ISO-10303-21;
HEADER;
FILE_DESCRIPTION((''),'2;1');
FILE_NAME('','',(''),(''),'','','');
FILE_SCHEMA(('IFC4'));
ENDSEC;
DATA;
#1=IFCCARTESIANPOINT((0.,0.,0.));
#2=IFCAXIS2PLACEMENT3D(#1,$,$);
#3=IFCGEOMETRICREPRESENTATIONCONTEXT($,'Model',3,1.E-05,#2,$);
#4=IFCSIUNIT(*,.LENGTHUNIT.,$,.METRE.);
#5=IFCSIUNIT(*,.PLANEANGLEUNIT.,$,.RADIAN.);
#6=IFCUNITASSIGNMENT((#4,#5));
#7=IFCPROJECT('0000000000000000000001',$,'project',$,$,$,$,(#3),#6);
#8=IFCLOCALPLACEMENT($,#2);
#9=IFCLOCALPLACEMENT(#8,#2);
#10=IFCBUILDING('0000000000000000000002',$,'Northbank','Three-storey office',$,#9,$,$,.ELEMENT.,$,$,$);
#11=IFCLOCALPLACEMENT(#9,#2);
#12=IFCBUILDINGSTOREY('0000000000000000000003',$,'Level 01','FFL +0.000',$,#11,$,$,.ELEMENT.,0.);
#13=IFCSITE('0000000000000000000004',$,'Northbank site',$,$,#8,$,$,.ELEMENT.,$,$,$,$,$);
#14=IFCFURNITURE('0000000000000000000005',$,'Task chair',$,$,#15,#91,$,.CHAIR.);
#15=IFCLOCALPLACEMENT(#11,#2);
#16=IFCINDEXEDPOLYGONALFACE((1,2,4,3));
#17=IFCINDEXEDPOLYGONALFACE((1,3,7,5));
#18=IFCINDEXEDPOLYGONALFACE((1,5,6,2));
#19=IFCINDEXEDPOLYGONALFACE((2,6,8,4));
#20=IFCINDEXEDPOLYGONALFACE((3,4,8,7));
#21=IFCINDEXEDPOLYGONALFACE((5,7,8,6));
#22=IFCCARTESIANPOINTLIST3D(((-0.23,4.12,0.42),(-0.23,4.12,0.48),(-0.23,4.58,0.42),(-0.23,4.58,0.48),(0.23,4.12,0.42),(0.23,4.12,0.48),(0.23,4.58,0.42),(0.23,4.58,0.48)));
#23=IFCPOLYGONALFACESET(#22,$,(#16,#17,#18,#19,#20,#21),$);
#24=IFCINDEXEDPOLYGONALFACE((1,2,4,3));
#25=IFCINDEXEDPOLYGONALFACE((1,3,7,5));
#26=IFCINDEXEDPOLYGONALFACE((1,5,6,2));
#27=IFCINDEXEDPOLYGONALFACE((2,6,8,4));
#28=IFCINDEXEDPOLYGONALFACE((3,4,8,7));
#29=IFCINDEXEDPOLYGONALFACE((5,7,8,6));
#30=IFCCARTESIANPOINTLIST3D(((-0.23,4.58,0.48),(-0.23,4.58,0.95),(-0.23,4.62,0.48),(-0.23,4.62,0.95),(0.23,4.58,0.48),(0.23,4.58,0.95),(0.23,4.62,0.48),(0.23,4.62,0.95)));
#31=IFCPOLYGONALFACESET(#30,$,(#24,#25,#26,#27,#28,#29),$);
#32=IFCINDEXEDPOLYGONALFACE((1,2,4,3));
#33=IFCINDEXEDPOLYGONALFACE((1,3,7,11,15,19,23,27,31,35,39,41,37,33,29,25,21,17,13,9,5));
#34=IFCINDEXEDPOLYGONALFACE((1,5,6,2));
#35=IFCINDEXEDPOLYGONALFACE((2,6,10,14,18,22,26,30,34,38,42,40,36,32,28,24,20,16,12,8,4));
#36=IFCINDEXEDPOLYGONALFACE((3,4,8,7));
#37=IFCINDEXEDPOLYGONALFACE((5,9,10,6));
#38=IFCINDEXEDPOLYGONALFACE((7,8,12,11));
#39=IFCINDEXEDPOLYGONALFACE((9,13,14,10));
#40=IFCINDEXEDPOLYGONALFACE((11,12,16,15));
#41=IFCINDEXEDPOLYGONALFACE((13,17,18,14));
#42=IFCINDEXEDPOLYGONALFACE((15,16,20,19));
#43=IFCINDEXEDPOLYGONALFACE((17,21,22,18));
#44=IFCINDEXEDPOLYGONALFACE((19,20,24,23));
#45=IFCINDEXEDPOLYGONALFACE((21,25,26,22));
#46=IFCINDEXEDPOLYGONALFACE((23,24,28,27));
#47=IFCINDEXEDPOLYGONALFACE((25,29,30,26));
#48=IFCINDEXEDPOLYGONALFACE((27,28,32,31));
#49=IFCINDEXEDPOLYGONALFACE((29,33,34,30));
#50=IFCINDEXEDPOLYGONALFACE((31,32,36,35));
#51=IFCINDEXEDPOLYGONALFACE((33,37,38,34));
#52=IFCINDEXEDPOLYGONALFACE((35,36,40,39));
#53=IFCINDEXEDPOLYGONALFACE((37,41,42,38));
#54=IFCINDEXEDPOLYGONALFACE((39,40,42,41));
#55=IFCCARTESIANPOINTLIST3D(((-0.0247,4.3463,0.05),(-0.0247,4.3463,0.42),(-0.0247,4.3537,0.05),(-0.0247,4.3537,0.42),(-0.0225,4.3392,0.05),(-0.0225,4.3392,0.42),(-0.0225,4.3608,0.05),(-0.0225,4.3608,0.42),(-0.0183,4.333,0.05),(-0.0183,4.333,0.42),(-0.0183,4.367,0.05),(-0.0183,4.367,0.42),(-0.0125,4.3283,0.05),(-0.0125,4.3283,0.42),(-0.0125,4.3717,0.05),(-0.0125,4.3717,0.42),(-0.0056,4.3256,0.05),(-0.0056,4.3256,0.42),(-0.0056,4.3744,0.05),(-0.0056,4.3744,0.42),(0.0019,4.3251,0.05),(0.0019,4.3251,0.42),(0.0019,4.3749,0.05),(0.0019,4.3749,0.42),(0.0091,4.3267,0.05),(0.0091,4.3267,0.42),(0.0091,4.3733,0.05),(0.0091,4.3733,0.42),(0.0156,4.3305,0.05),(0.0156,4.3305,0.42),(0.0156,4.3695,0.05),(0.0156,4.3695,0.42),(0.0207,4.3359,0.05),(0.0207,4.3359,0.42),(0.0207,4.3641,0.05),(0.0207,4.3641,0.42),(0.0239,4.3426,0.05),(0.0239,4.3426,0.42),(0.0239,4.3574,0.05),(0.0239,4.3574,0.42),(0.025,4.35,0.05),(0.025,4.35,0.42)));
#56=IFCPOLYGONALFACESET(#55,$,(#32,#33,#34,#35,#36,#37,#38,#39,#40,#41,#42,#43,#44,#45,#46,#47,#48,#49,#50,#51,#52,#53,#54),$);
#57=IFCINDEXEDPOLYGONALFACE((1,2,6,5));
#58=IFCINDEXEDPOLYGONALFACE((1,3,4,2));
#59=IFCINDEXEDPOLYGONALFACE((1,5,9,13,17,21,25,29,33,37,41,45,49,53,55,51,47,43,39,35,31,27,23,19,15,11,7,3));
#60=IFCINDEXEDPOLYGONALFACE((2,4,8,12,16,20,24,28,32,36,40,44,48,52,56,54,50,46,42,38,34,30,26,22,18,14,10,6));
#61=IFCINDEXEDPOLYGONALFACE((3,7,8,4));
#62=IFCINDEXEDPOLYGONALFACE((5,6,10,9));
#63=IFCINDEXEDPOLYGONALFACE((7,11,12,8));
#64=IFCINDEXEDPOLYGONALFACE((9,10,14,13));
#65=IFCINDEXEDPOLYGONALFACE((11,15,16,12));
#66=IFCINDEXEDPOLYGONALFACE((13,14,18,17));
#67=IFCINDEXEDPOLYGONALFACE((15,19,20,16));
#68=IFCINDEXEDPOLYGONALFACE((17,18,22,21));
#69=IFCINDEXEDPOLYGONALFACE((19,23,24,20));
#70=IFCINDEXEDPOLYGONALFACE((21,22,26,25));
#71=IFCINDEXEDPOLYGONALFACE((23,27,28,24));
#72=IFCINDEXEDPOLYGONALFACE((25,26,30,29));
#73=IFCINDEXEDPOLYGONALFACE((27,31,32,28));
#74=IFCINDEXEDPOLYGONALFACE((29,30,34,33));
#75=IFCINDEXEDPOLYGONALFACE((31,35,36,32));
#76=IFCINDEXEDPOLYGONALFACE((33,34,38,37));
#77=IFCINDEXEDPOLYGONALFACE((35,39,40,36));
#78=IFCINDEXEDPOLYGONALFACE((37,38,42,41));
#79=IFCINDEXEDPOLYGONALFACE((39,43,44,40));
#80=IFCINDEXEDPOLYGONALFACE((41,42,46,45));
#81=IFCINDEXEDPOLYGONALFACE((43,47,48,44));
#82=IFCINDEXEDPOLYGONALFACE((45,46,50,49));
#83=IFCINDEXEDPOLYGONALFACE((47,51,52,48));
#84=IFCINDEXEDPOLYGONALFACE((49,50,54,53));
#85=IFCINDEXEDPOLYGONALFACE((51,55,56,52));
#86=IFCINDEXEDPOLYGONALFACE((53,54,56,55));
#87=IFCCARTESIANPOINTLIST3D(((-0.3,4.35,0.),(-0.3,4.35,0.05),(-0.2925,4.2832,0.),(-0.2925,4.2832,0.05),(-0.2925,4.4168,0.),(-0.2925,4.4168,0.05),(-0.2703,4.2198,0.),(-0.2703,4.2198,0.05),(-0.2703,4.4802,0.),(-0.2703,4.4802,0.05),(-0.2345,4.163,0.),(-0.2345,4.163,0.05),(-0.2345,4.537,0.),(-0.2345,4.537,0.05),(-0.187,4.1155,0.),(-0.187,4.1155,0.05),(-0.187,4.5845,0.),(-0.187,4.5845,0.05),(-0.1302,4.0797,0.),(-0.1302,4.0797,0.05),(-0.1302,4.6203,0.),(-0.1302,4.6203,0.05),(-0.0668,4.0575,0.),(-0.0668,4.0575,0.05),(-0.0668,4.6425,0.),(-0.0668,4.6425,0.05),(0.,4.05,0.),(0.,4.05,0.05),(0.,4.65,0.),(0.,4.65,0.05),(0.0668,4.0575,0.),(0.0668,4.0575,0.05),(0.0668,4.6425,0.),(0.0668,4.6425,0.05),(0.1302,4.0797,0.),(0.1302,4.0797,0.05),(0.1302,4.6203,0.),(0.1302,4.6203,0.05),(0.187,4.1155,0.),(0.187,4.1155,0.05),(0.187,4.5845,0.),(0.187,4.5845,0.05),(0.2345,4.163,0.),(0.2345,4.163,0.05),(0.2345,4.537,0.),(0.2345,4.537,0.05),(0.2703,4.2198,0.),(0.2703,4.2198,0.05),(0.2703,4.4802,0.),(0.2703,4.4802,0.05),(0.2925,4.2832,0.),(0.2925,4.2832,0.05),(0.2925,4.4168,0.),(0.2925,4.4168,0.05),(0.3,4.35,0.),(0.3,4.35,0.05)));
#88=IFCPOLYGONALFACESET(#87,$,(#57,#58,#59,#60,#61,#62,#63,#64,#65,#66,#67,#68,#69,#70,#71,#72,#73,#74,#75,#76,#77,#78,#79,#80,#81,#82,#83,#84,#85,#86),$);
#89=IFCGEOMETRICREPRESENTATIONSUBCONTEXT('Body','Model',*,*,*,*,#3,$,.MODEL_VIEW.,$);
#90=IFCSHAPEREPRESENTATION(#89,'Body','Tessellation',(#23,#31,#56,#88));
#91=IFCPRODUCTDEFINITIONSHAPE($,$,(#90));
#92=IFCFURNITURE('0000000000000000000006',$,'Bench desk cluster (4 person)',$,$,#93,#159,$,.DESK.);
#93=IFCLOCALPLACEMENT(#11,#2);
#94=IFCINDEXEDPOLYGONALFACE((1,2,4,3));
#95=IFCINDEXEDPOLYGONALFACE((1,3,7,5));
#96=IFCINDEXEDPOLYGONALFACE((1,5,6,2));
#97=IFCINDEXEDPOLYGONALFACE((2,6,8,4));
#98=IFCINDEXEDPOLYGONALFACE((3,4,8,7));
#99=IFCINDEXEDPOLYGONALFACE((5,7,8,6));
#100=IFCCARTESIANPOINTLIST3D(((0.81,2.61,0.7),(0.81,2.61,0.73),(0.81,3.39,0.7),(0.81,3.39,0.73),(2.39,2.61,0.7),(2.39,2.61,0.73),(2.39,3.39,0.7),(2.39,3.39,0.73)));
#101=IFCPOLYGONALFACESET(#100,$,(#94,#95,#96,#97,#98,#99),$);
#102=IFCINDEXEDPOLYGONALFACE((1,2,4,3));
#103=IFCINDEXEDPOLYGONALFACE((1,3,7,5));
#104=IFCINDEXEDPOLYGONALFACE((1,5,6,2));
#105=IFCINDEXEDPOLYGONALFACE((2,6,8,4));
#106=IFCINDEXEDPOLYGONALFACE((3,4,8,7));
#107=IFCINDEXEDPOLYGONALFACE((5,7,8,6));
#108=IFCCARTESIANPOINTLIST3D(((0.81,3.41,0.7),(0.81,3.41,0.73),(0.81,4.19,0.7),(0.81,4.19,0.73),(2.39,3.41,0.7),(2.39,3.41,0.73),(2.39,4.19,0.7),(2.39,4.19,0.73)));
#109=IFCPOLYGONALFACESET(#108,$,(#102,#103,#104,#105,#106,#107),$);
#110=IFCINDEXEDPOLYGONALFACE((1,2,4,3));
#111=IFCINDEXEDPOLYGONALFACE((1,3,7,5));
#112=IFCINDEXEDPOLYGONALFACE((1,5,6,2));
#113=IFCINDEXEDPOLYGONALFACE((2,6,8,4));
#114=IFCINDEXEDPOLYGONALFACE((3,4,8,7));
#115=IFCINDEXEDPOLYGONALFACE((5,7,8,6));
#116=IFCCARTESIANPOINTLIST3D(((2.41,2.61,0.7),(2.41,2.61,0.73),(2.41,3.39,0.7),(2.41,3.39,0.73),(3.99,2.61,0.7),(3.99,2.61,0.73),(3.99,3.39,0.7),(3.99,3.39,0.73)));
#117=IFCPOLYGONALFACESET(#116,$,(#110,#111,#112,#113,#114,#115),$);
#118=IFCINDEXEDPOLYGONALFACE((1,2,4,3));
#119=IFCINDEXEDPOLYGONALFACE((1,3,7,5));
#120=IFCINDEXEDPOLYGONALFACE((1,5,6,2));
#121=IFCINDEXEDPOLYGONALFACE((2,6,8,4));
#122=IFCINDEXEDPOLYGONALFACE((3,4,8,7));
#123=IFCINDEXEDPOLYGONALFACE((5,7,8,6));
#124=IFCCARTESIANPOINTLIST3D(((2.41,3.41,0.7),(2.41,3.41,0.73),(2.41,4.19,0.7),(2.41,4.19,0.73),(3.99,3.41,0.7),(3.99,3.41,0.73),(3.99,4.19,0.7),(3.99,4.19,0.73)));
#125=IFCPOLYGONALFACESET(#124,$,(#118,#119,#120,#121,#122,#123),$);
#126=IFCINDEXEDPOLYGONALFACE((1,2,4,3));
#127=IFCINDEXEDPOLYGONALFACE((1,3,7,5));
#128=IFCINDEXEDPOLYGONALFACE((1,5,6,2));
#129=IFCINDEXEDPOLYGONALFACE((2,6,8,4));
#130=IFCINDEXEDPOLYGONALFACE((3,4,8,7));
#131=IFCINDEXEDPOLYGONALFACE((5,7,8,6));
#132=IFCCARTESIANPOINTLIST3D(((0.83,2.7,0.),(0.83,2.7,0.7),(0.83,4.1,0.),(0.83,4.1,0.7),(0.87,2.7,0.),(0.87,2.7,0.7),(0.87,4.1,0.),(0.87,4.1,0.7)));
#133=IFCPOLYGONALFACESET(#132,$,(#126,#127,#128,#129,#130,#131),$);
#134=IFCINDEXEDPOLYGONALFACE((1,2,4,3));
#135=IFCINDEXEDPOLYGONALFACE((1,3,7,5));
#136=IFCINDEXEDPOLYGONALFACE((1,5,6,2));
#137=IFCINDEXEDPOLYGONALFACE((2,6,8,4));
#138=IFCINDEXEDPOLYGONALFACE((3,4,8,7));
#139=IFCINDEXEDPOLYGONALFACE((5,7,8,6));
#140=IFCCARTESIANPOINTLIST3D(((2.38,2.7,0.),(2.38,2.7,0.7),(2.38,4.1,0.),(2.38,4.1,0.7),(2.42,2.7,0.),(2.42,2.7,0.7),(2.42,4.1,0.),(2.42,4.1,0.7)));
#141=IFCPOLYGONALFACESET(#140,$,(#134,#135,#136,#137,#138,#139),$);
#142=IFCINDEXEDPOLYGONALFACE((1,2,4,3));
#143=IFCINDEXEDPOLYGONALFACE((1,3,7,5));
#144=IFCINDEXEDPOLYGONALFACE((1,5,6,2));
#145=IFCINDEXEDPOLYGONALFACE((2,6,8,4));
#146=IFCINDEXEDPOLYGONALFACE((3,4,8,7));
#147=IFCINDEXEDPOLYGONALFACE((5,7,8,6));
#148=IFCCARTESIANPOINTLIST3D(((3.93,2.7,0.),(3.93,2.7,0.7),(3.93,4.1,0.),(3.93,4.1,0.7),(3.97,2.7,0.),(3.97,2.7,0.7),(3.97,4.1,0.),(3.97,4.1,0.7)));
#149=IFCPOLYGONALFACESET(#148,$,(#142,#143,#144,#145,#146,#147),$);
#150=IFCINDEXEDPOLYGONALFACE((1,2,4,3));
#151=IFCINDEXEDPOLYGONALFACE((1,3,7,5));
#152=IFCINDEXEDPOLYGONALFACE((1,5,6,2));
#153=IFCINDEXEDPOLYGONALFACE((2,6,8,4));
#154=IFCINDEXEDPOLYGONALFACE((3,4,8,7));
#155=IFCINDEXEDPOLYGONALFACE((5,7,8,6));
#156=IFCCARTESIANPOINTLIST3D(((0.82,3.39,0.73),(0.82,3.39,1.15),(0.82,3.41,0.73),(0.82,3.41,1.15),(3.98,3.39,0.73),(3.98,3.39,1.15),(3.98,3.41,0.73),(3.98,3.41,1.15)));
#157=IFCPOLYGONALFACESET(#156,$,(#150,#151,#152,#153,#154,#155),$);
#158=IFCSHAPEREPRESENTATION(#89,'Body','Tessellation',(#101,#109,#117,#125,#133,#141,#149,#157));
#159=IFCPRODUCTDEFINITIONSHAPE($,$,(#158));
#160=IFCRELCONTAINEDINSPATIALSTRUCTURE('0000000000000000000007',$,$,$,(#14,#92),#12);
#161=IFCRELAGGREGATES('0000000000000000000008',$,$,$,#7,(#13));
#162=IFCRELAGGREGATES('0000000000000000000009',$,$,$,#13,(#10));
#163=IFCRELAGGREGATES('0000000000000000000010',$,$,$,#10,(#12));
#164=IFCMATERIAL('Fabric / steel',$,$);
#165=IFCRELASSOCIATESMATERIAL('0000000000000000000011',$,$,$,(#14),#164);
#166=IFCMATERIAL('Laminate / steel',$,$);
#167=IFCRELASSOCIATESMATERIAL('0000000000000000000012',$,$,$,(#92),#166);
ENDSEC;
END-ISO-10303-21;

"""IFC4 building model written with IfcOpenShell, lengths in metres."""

from ifc_helpers import new_model, si_unit, frame, origin, place, context, subcontext, project, spatial, rectangle, circle, extrude, material, element, save


model = new_model("IFC4")

# Units and contexts
model_context = context("Model", 3, precision=1e-05, world=origin())
body_context = subcontext(model_context, "Body", "Model", "MODEL_VIEW")
ifc_project = project(units=[si_unit("LENGTHUNIT", "METRE"), si_unit("PLANEANGLEUNIT", "RADIAN")], contexts=[model_context])

# Site, building, storey
site_placement = place(None, origin())
site = spatial("IfcSite", under=ifc_project, at=site_placement, Name="Northbank site", CompositionType="ELEMENT")
building_placement = place(site_placement, origin())
building = spatial("IfcBuilding", under=site, at=building_placement, Name="Northbank", Description="Three-storey office", CompositionType="ELEMENT")
storey_placement = place(building_placement, origin())
storey = spatial("IfcBuildingStorey", under=building, at=storey_placement, Name="Level 01", Description="FFL +0.000", CompositionType="ELEMENT", Elevation=0.0)

# Furniture
ifc_material_1 = material(Name="Laminate / steel")
ifc_material_2 = material(Name="Fabric / steel")
furniture_1_placement = place(storey_placement, origin())
element("IfcFurniture", 1, at=furniture_1_placement, inside=storey, material=ifc_material_2, Name="Task chair", PredefinedType="CHAIR", context=body_context, shape_type="SweptSolid", body=[
    extrude(rectangle(XDim=0.46, YDim=0.46), frame((0.0, 4.35, 0.42)), (0.0, 0.0, 1.0), 0.06),
    extrude(rectangle(XDim=0.46, YDim=0.04), frame((0.0, 4.6, 0.48)), (0.0, 0.0, 1.0), 0.47),
    extrude(circle(Radius=0.025), frame((0.0, 4.35, 0.05), z_axis=(0.0, 0.0, 1.0), x_axis=(1.0, 0.0, 0.0)), (0.0, 0.0, 1.0), 0.37),
    extrude(circle(Radius=0.3), frame((0.0, 4.35, 0.0), z_axis=(0.0, 0.0, 1.0), x_axis=(1.0, 0.0, 0.0)), (0.0, 0.0, 1.0), 0.05),
])
furniture_2_placement = place(storey_placement, origin())
element("IfcFurniture", 2, at=furniture_2_placement, inside=storey, material=ifc_material_1, Name="Bench desk cluster (4 person)", PredefinedType="DESK", context=body_context, shape_type="SweptSolid", body=[
    extrude(rectangle(XDim=1.58, YDim=0.78), frame((1.6, 3.0, 0.7)), (0.0, 0.0, 1.0), 0.03),
    extrude(rectangle(XDim=1.58, YDim=0.78), frame((1.6, 3.8, 0.7)), (0.0, 0.0, 1.0), 0.03),
    extrude(rectangle(XDim=1.58, YDim=0.78), frame((3.2, 3.0, 0.7)), (0.0, 0.0, 1.0), 0.03),
    extrude(rectangle(XDim=1.58, YDim=0.78), frame((3.2, 3.8, 0.7)), (0.0, 0.0, 1.0), 0.03),
    extrude(rectangle(XDim=0.04, YDim=1.4), frame((0.85, 3.4, 0.0)), (0.0, 0.0, 1.0), 0.7),
    extrude(rectangle(XDim=0.04, YDim=1.4), frame((2.4, 3.4, 0.0)), (0.0, 0.0, 1.0), 0.7),
    extrude(rectangle(XDim=0.04, YDim=1.4), frame((3.95, 3.4, 0.0)), (0.0, 0.0, 1.0), 0.7),
    extrude(rectangle(XDim=3.16, YDim=0.02), frame((2.4, 3.4, 0.73)), (0.0, 0.0, 1.0), 0.42),
])

save(model, "model.ifc")
